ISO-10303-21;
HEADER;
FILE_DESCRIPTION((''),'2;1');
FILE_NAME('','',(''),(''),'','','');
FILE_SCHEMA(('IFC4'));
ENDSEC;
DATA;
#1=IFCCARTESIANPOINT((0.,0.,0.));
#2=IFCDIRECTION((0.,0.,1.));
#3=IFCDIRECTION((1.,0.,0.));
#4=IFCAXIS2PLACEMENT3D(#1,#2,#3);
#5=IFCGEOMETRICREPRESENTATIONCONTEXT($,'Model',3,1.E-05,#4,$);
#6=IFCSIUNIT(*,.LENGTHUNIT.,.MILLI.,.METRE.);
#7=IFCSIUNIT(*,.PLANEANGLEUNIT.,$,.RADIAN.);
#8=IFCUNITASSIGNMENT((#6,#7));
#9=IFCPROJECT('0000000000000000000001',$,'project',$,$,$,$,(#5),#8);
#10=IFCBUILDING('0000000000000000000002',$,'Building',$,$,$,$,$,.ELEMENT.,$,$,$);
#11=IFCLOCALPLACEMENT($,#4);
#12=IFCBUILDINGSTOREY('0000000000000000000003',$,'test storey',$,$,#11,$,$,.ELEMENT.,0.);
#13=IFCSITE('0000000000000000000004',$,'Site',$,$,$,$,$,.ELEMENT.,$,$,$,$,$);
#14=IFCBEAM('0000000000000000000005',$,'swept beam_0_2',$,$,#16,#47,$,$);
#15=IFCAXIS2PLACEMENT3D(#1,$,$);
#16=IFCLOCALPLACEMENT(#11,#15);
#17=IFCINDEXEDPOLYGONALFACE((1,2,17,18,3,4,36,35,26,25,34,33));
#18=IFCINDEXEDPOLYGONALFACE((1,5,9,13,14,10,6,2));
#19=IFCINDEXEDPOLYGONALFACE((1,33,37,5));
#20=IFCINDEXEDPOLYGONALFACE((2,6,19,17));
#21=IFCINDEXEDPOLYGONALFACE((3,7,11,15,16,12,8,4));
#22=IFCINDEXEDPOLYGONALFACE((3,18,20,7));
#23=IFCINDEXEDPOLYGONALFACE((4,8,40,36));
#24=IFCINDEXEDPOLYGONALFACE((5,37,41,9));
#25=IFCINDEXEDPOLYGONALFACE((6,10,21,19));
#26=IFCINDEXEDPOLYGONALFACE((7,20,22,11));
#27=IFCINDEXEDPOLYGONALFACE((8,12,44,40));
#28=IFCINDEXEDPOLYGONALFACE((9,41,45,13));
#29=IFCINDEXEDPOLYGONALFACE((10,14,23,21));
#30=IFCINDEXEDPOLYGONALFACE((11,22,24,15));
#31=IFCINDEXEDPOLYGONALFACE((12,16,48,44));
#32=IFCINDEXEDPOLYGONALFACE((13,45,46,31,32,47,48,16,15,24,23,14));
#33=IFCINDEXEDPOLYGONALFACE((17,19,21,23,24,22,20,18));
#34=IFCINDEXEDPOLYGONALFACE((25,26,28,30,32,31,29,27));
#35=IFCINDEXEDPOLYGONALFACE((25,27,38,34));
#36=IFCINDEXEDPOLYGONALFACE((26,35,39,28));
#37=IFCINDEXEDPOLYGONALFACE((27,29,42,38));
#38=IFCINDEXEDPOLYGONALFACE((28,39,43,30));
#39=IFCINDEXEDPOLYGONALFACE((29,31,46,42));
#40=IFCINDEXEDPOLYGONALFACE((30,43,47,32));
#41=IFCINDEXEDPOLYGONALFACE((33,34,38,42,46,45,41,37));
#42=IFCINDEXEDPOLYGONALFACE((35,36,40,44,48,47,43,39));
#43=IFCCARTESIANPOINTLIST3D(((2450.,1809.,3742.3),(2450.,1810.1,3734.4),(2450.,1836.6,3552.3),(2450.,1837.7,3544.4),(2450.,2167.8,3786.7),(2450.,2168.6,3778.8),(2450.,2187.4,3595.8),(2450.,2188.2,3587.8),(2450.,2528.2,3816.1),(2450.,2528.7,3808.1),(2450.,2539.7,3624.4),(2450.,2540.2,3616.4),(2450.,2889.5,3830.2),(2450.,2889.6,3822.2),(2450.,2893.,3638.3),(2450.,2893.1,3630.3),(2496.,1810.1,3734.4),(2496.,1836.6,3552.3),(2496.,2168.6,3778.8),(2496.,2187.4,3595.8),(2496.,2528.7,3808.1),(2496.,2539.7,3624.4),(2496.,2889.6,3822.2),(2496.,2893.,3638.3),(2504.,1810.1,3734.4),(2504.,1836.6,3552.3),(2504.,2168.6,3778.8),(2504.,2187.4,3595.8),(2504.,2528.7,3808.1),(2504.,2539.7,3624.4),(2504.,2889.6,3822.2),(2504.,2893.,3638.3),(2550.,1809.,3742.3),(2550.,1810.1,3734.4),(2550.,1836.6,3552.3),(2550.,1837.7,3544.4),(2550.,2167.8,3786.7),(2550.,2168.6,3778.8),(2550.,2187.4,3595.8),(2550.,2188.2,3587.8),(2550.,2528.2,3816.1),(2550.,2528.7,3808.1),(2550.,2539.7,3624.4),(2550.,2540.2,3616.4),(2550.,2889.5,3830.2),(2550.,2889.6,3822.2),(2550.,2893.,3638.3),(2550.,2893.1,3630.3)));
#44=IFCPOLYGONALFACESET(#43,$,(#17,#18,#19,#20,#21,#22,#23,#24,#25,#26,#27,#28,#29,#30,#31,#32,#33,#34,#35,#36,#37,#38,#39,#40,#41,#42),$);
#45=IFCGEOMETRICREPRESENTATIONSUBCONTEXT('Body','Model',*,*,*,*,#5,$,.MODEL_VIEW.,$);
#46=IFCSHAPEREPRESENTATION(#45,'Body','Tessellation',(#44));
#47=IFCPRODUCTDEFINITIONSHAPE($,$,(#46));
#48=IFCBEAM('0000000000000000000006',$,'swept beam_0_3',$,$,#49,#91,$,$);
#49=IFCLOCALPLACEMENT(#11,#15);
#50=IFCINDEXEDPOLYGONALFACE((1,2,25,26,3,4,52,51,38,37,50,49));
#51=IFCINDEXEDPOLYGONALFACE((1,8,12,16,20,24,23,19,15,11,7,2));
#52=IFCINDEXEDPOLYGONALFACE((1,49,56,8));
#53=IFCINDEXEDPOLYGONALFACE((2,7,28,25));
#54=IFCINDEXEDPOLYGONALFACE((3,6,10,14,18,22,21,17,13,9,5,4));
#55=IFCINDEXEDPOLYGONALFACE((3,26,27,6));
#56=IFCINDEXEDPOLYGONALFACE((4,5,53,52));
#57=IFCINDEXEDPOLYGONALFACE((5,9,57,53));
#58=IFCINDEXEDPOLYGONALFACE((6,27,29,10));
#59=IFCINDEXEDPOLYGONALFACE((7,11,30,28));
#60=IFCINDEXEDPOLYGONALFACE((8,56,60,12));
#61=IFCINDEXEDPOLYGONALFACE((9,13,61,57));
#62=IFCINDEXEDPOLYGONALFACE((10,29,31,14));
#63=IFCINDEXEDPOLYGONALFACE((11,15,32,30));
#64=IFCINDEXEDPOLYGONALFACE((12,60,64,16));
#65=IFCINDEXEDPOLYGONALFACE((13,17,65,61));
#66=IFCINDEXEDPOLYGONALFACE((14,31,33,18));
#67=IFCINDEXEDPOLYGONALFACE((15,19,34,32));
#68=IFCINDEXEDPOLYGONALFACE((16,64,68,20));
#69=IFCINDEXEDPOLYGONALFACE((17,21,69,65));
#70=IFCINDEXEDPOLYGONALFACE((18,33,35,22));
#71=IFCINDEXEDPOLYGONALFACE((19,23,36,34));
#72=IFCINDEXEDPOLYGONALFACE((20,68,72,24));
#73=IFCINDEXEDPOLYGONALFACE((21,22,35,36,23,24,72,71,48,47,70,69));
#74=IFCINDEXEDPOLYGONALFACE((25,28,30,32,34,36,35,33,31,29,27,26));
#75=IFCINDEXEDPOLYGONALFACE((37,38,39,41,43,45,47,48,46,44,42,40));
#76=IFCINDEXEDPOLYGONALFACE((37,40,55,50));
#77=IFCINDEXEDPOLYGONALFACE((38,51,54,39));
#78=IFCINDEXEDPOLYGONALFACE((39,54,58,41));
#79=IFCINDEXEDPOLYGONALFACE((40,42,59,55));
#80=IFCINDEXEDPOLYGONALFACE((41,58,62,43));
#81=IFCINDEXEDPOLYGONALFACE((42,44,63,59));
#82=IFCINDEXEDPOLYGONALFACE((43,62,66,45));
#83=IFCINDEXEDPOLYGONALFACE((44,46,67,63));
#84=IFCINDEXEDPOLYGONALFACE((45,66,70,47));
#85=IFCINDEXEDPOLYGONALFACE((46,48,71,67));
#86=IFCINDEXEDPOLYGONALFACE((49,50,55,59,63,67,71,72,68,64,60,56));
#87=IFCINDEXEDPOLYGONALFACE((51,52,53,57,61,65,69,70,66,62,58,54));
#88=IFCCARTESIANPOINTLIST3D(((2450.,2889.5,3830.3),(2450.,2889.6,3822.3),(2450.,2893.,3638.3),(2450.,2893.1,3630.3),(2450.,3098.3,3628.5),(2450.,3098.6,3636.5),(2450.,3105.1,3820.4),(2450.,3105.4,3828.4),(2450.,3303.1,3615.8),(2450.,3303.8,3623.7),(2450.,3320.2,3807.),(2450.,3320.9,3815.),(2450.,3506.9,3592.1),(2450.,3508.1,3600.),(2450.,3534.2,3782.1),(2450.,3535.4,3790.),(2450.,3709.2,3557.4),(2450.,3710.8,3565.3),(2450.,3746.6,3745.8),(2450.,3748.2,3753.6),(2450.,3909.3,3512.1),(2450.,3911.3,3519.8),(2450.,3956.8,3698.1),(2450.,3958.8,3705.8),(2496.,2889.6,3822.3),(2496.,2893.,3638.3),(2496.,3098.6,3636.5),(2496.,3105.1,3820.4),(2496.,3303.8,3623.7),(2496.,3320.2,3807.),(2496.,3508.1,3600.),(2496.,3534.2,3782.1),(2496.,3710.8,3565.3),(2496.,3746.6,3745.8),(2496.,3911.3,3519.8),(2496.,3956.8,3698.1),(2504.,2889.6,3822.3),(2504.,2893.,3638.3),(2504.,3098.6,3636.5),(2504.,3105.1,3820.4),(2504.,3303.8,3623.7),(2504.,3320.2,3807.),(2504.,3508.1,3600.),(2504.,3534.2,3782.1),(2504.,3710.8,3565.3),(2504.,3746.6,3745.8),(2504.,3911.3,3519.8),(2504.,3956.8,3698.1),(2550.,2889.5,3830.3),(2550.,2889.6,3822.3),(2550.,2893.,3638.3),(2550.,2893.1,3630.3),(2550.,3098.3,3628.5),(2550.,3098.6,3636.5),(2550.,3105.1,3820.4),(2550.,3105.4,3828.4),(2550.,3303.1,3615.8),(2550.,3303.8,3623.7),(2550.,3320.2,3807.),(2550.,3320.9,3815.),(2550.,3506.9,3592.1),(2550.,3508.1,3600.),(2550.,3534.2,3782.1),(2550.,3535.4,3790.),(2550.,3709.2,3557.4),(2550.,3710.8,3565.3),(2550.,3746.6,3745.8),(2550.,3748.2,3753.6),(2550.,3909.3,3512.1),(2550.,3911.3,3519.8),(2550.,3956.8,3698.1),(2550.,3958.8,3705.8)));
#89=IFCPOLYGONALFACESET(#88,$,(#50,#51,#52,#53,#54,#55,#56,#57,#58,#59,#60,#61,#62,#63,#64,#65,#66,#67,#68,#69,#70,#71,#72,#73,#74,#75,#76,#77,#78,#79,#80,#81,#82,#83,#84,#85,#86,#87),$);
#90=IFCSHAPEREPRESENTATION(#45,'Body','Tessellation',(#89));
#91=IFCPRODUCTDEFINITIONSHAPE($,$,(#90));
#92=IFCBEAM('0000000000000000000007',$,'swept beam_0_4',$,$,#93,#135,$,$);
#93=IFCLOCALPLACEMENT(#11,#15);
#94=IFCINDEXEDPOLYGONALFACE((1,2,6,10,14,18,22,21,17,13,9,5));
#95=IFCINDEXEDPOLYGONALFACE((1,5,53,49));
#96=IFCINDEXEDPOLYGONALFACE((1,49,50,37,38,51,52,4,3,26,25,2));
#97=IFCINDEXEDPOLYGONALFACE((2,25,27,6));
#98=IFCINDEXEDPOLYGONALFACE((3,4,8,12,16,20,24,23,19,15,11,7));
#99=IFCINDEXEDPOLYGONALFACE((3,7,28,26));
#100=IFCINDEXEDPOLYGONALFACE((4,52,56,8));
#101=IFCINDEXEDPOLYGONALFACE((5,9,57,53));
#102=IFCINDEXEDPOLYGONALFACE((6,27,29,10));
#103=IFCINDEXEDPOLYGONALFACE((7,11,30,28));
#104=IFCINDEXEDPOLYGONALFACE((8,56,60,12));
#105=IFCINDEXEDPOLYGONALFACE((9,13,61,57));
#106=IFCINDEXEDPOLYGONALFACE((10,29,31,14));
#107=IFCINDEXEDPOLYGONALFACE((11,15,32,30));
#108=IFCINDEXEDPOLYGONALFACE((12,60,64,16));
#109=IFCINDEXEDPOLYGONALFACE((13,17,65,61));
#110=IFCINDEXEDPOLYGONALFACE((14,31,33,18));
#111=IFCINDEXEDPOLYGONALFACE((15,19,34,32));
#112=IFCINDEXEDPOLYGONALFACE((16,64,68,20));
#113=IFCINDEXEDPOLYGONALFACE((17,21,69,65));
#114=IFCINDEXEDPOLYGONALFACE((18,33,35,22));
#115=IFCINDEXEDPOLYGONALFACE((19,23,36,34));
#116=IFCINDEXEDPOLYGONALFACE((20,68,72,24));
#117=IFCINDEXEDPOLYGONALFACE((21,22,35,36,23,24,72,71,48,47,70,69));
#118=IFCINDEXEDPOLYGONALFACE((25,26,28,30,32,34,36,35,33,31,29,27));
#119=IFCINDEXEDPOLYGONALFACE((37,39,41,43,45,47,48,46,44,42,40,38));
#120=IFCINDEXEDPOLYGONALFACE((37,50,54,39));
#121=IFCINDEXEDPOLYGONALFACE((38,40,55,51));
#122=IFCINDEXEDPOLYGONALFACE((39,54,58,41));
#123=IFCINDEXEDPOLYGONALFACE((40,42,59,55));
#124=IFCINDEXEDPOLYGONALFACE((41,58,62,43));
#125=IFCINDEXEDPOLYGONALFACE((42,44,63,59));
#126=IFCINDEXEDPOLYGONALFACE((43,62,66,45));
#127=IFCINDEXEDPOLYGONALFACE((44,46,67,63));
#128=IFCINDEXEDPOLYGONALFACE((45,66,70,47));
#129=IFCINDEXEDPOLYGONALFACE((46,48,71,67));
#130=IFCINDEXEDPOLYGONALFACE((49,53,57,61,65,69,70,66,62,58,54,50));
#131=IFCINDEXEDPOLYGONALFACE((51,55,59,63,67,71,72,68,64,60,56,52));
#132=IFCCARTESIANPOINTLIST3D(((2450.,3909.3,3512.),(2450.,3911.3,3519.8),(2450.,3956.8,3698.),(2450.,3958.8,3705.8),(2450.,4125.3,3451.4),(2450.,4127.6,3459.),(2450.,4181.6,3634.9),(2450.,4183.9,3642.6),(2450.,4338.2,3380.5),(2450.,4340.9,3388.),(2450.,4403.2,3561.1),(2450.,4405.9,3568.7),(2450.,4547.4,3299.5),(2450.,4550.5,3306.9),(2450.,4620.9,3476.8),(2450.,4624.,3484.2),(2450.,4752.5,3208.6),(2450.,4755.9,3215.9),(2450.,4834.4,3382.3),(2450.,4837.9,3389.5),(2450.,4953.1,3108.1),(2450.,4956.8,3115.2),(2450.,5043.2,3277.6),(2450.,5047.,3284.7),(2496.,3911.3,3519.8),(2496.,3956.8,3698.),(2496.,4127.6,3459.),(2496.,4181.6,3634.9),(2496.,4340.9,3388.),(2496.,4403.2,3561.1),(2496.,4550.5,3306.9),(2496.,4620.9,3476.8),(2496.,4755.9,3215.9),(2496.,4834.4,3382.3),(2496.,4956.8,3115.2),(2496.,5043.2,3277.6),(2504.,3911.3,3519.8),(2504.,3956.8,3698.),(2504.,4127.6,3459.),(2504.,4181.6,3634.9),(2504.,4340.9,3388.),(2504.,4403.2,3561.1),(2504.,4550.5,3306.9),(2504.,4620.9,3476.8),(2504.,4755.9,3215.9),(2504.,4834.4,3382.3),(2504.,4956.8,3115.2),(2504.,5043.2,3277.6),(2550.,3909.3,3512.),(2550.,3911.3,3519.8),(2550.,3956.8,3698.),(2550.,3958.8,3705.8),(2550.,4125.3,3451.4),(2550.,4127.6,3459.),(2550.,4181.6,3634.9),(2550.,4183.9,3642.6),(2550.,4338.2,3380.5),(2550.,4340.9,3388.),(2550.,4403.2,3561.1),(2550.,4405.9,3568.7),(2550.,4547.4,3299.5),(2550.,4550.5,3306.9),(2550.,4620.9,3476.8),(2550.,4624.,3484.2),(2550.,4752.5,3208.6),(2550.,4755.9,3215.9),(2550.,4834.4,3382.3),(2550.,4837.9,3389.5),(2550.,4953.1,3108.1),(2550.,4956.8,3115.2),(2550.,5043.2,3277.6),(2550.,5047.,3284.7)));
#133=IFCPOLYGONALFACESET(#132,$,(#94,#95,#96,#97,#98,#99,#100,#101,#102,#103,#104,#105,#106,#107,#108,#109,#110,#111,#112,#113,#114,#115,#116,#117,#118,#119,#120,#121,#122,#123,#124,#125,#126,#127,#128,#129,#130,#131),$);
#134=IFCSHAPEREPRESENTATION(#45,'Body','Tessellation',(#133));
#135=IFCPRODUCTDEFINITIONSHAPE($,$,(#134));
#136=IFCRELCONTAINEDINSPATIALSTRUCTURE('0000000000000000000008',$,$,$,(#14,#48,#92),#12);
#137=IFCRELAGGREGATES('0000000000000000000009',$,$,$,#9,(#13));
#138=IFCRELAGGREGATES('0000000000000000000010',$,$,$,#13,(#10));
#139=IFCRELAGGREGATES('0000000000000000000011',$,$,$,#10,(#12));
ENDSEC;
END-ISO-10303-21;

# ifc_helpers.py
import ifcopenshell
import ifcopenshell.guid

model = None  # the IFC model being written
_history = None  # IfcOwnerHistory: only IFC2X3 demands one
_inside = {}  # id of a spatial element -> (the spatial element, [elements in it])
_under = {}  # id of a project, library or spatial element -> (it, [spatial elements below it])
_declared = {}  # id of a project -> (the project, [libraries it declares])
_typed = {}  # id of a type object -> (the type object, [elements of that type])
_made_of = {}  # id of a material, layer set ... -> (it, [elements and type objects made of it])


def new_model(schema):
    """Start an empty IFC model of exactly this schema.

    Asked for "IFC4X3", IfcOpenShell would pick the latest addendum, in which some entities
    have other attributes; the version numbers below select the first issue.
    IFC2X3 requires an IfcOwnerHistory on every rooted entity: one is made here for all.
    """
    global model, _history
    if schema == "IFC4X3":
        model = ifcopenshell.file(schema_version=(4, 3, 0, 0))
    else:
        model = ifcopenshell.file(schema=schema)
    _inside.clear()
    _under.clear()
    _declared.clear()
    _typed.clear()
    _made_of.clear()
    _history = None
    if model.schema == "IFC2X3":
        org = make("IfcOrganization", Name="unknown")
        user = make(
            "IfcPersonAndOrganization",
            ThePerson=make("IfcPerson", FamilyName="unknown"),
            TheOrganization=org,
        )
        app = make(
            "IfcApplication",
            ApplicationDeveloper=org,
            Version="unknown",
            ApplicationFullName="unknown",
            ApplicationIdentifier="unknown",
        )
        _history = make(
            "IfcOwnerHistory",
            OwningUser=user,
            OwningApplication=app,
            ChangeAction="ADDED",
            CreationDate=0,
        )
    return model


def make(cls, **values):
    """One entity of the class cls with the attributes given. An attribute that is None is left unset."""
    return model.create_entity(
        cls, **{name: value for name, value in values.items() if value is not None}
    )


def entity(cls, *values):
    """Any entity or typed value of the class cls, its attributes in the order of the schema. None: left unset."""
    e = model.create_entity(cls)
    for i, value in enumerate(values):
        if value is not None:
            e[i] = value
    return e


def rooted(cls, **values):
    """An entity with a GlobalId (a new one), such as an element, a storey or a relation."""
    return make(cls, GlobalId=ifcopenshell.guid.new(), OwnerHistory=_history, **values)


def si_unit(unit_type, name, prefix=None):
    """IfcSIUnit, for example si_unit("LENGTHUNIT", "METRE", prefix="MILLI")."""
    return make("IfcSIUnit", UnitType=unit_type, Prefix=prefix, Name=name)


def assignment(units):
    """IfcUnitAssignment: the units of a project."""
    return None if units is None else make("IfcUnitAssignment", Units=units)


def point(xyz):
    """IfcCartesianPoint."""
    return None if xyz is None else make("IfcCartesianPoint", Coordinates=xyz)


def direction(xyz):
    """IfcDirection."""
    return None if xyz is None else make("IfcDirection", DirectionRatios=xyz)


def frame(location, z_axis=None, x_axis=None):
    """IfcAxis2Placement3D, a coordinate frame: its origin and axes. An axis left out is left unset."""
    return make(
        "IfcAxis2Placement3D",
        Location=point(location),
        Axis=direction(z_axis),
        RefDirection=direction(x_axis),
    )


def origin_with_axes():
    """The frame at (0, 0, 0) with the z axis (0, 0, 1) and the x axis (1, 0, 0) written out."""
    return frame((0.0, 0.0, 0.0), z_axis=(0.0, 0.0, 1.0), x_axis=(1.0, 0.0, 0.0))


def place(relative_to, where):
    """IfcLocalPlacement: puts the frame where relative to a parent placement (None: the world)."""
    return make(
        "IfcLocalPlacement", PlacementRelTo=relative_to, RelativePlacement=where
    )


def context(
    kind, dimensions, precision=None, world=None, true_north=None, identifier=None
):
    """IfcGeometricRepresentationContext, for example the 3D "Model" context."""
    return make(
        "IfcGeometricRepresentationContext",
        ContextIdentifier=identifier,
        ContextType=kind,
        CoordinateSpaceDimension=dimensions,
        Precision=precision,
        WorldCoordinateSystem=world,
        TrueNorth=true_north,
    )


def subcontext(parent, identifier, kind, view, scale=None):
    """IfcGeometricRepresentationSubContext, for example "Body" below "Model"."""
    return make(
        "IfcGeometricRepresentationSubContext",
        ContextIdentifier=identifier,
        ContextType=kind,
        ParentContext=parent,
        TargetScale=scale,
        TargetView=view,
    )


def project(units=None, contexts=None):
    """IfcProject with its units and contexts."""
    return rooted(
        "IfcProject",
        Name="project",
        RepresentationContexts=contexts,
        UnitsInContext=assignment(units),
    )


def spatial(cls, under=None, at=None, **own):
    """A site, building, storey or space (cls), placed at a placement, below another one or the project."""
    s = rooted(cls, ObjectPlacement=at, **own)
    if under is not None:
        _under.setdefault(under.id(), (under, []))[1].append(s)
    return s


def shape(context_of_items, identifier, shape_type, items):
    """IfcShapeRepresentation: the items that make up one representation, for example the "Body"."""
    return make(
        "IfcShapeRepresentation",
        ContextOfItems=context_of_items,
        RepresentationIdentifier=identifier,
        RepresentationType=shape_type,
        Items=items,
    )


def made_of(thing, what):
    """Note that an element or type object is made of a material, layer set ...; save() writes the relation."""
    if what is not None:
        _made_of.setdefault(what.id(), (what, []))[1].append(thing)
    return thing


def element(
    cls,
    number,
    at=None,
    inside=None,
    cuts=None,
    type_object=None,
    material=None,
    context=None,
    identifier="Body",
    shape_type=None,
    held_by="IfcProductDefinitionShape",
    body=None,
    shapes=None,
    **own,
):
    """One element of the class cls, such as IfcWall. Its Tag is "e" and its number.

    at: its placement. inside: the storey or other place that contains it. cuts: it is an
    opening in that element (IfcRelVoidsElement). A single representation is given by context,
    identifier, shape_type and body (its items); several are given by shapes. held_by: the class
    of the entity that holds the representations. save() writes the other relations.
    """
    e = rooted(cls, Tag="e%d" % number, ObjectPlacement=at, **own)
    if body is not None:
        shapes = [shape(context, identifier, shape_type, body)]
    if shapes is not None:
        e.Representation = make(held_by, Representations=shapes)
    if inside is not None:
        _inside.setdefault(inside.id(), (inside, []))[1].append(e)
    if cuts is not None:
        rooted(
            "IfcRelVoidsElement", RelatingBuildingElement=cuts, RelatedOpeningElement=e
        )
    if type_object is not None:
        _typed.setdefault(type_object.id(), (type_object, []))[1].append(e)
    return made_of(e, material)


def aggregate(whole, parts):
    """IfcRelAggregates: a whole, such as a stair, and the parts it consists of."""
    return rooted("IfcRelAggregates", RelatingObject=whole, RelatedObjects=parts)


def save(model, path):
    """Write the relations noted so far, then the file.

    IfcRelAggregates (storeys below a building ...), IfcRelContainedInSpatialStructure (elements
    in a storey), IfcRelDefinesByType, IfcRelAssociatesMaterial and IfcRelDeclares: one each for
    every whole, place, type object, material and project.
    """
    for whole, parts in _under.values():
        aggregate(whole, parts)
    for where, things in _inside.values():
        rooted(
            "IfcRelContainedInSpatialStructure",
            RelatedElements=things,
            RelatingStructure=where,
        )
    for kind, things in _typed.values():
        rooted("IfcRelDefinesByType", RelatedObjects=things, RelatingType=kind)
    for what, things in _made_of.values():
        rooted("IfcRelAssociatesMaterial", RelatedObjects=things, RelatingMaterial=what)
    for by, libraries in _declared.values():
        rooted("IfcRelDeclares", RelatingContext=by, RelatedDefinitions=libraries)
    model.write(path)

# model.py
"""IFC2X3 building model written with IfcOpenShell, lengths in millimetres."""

from ifc_helpers import new_model, entity, si_unit, origin_with_axes, place, context, subcontext, project, spatial, element, save


model = new_model("IFC2X3")

# Units and contexts
model_context = context("Model", 3, precision=1e-05, world=origin_with_axes())
body_context = subcontext(model_context, "Body", "Model", "MODEL_VIEW")
ifc_project = project(units=[si_unit("LENGTHUNIT", "METRE", prefix="MILLI"), si_unit("PLANEANGLEUNIT", "RADIAN")], contexts=[model_context])

# Site, building, storey
site = spatial("IfcSite", under=ifc_project, Name="Site", CompositionType="ELEMENT")
building = spatial("IfcBuilding", under=site, Name="Building", CompositionType="ELEMENT")
storey_placement = place(None, origin_with_axes())
storey = spatial("IfcBuildingStorey", under=building, at=storey_placement, Name="test storey", CompositionType="ELEMENT", Elevation=0.0)

# Beams
beam_1_placement = place(storey_placement, origin_with_axes())
element("IfcBeam", 1, at=beam_1_placement, inside=storey, Name="swept beam_0_2", context=body_context, shape_type="SweptSolid", body=[
    entity("IfcRevolvedAreaSolid", entity("IfcArbitraryClosedProfileDef", "AREA", None, entity("IfcPolyline", [entity("IfcCartesianPoint", [-192.0, -50.0]), entity("IfcCartesianPoint", [-192.0, -4.0]), entity("IfcCartesianPoint", [-8.0, -4.0]), entity("IfcCartesianPoint", [-8.0, -50.0]), entity("IfcCartesianPoint", [0.0, -50.0]), entity("IfcCartesianPoint", [0.0, 50.0]), entity("IfcCartesianPoint", [-8.0, 50.0]), entity("IfcCartesianPoint", [-8.0, 4.0]), entity("IfcCartesianPoint", [-192.0, 4.0]), entity("IfcCartesianPoint", [-192.0, 50.0]), entity("IfcCartesianPoint", [-200.0, 50.0]), entity("IfcCartesianPoint", [-200.0, -50.0]), entity("IfcCartesianPoint", [-192.0, -50.0])])), entity("IfcAxis2Placement3D", entity("IfcCartesianPoint", [2500.0, 1809.0, 3742.3]), entity("IfcDirection", [0.0, -0.9896, -0.1438]), entity("IfcDirection", [0.0, -0.1438, 0.9896])), entity("IfcAxis1Placement", entity("IfcCartesianPoint", [-8598.3, 0.0, 0.0]), entity("IfcDirection", [0.0, 1.0, 0.0])), 0.126165),
])
beam_2_placement = place(storey_placement, origin_with_axes())
element("IfcBeam", 2, at=beam_2_placement, inside=storey, Name="swept beam_0_3", context=body_context, shape_type="SweptSolid", body=[
    entity("IfcRevolvedAreaSolid", entity("IfcArbitraryClosedProfileDef", "AREA", None, entity("IfcPolyline", [entity("IfcCartesianPoint", [-192.0, -50.0]), entity("IfcCartesianPoint", [-192.0, -4.0]), entity("IfcCartesianPoint", [-8.0, -4.0]), entity("IfcCartesianPoint", [-8.0, -50.0]), entity("IfcCartesianPoint", [0.0, -50.0]), entity("IfcCartesianPoint", [0.0, 50.0]), entity("IfcCartesianPoint", [-8.0, 50.0]), entity("IfcCartesianPoint", [-8.0, 4.0]), entity("IfcCartesianPoint", [-192.0, 4.0]), entity("IfcCartesianPoint", [-192.0, 50.0]), entity("IfcCartesianPoint", [-200.0, 50.0]), entity("IfcCartesianPoint", [-200.0, -50.0]), entity("IfcCartesianPoint", [-192.0, -50.0])])), entity("IfcAxis2Placement3D", entity("IfcCartesianPoint", [2500.0, 2889.5, 3830.3]), entity("IfcDirection", [0.0, -0.9998, -0.0182]), entity("IfcDirection", [0.0, -0.0182, 0.9998])), entity("IfcAxis1Placement", entity("IfcCartesianPoint", [-4027.8, 0.0, 0.0]), entity("IfcDirection", [0.0, 1.0, 0.0])), 0.268074),
])
beam_3_placement = place(storey_placement, origin_with_axes())
element("IfcBeam", 3, at=beam_3_placement, inside=storey, Name="swept beam_0_4", context=body_context, shape_type="SweptSolid", body=[
    entity("IfcRevolvedAreaSolid", entity("IfcArbitraryClosedProfileDef", "AREA", None, entity("IfcPolyline", [entity("IfcCartesianPoint", [-192.0, -50.0]), entity("IfcCartesianPoint", [-192.0, -4.0]), entity("IfcCartesianPoint", [-8.0, -4.0]), entity("IfcCartesianPoint", [-8.0, -50.0]), entity("IfcCartesianPoint", [0.0, -50.0]), entity("IfcCartesianPoint", [0.0, 50.0]), entity("IfcCartesianPoint", [-8.0, 50.0]), entity("IfcCartesianPoint", [-8.0, 4.0]), entity("IfcCartesianPoint", [-192.0, 4.0]), entity("IfcCartesianPoint", [-192.0, 50.0]), entity("IfcCartesianPoint", [-200.0, 50.0]), entity("IfcCartesianPoint", [-200.0, -50.0]), entity("IfcCartesianPoint", [-192.0, -50.0])])), entity("IfcAxis2Placement3D", entity("IfcCartesianPoint", [2500.0, 3958.8, 3705.8]), entity("IfcDirection", [0.0, -0.9689, 0.2473]), entity("IfcDirection", [0.0, 0.2473, 0.9689])), entity("IfcAxis1Placement", entity("IfcCartesianPoint", [-4901.0, 0.0, 0.0]), entity("IfcDirection", [0.0, 1.0, 0.0])), 0.238649),
])

save(model, "model.ifc")
